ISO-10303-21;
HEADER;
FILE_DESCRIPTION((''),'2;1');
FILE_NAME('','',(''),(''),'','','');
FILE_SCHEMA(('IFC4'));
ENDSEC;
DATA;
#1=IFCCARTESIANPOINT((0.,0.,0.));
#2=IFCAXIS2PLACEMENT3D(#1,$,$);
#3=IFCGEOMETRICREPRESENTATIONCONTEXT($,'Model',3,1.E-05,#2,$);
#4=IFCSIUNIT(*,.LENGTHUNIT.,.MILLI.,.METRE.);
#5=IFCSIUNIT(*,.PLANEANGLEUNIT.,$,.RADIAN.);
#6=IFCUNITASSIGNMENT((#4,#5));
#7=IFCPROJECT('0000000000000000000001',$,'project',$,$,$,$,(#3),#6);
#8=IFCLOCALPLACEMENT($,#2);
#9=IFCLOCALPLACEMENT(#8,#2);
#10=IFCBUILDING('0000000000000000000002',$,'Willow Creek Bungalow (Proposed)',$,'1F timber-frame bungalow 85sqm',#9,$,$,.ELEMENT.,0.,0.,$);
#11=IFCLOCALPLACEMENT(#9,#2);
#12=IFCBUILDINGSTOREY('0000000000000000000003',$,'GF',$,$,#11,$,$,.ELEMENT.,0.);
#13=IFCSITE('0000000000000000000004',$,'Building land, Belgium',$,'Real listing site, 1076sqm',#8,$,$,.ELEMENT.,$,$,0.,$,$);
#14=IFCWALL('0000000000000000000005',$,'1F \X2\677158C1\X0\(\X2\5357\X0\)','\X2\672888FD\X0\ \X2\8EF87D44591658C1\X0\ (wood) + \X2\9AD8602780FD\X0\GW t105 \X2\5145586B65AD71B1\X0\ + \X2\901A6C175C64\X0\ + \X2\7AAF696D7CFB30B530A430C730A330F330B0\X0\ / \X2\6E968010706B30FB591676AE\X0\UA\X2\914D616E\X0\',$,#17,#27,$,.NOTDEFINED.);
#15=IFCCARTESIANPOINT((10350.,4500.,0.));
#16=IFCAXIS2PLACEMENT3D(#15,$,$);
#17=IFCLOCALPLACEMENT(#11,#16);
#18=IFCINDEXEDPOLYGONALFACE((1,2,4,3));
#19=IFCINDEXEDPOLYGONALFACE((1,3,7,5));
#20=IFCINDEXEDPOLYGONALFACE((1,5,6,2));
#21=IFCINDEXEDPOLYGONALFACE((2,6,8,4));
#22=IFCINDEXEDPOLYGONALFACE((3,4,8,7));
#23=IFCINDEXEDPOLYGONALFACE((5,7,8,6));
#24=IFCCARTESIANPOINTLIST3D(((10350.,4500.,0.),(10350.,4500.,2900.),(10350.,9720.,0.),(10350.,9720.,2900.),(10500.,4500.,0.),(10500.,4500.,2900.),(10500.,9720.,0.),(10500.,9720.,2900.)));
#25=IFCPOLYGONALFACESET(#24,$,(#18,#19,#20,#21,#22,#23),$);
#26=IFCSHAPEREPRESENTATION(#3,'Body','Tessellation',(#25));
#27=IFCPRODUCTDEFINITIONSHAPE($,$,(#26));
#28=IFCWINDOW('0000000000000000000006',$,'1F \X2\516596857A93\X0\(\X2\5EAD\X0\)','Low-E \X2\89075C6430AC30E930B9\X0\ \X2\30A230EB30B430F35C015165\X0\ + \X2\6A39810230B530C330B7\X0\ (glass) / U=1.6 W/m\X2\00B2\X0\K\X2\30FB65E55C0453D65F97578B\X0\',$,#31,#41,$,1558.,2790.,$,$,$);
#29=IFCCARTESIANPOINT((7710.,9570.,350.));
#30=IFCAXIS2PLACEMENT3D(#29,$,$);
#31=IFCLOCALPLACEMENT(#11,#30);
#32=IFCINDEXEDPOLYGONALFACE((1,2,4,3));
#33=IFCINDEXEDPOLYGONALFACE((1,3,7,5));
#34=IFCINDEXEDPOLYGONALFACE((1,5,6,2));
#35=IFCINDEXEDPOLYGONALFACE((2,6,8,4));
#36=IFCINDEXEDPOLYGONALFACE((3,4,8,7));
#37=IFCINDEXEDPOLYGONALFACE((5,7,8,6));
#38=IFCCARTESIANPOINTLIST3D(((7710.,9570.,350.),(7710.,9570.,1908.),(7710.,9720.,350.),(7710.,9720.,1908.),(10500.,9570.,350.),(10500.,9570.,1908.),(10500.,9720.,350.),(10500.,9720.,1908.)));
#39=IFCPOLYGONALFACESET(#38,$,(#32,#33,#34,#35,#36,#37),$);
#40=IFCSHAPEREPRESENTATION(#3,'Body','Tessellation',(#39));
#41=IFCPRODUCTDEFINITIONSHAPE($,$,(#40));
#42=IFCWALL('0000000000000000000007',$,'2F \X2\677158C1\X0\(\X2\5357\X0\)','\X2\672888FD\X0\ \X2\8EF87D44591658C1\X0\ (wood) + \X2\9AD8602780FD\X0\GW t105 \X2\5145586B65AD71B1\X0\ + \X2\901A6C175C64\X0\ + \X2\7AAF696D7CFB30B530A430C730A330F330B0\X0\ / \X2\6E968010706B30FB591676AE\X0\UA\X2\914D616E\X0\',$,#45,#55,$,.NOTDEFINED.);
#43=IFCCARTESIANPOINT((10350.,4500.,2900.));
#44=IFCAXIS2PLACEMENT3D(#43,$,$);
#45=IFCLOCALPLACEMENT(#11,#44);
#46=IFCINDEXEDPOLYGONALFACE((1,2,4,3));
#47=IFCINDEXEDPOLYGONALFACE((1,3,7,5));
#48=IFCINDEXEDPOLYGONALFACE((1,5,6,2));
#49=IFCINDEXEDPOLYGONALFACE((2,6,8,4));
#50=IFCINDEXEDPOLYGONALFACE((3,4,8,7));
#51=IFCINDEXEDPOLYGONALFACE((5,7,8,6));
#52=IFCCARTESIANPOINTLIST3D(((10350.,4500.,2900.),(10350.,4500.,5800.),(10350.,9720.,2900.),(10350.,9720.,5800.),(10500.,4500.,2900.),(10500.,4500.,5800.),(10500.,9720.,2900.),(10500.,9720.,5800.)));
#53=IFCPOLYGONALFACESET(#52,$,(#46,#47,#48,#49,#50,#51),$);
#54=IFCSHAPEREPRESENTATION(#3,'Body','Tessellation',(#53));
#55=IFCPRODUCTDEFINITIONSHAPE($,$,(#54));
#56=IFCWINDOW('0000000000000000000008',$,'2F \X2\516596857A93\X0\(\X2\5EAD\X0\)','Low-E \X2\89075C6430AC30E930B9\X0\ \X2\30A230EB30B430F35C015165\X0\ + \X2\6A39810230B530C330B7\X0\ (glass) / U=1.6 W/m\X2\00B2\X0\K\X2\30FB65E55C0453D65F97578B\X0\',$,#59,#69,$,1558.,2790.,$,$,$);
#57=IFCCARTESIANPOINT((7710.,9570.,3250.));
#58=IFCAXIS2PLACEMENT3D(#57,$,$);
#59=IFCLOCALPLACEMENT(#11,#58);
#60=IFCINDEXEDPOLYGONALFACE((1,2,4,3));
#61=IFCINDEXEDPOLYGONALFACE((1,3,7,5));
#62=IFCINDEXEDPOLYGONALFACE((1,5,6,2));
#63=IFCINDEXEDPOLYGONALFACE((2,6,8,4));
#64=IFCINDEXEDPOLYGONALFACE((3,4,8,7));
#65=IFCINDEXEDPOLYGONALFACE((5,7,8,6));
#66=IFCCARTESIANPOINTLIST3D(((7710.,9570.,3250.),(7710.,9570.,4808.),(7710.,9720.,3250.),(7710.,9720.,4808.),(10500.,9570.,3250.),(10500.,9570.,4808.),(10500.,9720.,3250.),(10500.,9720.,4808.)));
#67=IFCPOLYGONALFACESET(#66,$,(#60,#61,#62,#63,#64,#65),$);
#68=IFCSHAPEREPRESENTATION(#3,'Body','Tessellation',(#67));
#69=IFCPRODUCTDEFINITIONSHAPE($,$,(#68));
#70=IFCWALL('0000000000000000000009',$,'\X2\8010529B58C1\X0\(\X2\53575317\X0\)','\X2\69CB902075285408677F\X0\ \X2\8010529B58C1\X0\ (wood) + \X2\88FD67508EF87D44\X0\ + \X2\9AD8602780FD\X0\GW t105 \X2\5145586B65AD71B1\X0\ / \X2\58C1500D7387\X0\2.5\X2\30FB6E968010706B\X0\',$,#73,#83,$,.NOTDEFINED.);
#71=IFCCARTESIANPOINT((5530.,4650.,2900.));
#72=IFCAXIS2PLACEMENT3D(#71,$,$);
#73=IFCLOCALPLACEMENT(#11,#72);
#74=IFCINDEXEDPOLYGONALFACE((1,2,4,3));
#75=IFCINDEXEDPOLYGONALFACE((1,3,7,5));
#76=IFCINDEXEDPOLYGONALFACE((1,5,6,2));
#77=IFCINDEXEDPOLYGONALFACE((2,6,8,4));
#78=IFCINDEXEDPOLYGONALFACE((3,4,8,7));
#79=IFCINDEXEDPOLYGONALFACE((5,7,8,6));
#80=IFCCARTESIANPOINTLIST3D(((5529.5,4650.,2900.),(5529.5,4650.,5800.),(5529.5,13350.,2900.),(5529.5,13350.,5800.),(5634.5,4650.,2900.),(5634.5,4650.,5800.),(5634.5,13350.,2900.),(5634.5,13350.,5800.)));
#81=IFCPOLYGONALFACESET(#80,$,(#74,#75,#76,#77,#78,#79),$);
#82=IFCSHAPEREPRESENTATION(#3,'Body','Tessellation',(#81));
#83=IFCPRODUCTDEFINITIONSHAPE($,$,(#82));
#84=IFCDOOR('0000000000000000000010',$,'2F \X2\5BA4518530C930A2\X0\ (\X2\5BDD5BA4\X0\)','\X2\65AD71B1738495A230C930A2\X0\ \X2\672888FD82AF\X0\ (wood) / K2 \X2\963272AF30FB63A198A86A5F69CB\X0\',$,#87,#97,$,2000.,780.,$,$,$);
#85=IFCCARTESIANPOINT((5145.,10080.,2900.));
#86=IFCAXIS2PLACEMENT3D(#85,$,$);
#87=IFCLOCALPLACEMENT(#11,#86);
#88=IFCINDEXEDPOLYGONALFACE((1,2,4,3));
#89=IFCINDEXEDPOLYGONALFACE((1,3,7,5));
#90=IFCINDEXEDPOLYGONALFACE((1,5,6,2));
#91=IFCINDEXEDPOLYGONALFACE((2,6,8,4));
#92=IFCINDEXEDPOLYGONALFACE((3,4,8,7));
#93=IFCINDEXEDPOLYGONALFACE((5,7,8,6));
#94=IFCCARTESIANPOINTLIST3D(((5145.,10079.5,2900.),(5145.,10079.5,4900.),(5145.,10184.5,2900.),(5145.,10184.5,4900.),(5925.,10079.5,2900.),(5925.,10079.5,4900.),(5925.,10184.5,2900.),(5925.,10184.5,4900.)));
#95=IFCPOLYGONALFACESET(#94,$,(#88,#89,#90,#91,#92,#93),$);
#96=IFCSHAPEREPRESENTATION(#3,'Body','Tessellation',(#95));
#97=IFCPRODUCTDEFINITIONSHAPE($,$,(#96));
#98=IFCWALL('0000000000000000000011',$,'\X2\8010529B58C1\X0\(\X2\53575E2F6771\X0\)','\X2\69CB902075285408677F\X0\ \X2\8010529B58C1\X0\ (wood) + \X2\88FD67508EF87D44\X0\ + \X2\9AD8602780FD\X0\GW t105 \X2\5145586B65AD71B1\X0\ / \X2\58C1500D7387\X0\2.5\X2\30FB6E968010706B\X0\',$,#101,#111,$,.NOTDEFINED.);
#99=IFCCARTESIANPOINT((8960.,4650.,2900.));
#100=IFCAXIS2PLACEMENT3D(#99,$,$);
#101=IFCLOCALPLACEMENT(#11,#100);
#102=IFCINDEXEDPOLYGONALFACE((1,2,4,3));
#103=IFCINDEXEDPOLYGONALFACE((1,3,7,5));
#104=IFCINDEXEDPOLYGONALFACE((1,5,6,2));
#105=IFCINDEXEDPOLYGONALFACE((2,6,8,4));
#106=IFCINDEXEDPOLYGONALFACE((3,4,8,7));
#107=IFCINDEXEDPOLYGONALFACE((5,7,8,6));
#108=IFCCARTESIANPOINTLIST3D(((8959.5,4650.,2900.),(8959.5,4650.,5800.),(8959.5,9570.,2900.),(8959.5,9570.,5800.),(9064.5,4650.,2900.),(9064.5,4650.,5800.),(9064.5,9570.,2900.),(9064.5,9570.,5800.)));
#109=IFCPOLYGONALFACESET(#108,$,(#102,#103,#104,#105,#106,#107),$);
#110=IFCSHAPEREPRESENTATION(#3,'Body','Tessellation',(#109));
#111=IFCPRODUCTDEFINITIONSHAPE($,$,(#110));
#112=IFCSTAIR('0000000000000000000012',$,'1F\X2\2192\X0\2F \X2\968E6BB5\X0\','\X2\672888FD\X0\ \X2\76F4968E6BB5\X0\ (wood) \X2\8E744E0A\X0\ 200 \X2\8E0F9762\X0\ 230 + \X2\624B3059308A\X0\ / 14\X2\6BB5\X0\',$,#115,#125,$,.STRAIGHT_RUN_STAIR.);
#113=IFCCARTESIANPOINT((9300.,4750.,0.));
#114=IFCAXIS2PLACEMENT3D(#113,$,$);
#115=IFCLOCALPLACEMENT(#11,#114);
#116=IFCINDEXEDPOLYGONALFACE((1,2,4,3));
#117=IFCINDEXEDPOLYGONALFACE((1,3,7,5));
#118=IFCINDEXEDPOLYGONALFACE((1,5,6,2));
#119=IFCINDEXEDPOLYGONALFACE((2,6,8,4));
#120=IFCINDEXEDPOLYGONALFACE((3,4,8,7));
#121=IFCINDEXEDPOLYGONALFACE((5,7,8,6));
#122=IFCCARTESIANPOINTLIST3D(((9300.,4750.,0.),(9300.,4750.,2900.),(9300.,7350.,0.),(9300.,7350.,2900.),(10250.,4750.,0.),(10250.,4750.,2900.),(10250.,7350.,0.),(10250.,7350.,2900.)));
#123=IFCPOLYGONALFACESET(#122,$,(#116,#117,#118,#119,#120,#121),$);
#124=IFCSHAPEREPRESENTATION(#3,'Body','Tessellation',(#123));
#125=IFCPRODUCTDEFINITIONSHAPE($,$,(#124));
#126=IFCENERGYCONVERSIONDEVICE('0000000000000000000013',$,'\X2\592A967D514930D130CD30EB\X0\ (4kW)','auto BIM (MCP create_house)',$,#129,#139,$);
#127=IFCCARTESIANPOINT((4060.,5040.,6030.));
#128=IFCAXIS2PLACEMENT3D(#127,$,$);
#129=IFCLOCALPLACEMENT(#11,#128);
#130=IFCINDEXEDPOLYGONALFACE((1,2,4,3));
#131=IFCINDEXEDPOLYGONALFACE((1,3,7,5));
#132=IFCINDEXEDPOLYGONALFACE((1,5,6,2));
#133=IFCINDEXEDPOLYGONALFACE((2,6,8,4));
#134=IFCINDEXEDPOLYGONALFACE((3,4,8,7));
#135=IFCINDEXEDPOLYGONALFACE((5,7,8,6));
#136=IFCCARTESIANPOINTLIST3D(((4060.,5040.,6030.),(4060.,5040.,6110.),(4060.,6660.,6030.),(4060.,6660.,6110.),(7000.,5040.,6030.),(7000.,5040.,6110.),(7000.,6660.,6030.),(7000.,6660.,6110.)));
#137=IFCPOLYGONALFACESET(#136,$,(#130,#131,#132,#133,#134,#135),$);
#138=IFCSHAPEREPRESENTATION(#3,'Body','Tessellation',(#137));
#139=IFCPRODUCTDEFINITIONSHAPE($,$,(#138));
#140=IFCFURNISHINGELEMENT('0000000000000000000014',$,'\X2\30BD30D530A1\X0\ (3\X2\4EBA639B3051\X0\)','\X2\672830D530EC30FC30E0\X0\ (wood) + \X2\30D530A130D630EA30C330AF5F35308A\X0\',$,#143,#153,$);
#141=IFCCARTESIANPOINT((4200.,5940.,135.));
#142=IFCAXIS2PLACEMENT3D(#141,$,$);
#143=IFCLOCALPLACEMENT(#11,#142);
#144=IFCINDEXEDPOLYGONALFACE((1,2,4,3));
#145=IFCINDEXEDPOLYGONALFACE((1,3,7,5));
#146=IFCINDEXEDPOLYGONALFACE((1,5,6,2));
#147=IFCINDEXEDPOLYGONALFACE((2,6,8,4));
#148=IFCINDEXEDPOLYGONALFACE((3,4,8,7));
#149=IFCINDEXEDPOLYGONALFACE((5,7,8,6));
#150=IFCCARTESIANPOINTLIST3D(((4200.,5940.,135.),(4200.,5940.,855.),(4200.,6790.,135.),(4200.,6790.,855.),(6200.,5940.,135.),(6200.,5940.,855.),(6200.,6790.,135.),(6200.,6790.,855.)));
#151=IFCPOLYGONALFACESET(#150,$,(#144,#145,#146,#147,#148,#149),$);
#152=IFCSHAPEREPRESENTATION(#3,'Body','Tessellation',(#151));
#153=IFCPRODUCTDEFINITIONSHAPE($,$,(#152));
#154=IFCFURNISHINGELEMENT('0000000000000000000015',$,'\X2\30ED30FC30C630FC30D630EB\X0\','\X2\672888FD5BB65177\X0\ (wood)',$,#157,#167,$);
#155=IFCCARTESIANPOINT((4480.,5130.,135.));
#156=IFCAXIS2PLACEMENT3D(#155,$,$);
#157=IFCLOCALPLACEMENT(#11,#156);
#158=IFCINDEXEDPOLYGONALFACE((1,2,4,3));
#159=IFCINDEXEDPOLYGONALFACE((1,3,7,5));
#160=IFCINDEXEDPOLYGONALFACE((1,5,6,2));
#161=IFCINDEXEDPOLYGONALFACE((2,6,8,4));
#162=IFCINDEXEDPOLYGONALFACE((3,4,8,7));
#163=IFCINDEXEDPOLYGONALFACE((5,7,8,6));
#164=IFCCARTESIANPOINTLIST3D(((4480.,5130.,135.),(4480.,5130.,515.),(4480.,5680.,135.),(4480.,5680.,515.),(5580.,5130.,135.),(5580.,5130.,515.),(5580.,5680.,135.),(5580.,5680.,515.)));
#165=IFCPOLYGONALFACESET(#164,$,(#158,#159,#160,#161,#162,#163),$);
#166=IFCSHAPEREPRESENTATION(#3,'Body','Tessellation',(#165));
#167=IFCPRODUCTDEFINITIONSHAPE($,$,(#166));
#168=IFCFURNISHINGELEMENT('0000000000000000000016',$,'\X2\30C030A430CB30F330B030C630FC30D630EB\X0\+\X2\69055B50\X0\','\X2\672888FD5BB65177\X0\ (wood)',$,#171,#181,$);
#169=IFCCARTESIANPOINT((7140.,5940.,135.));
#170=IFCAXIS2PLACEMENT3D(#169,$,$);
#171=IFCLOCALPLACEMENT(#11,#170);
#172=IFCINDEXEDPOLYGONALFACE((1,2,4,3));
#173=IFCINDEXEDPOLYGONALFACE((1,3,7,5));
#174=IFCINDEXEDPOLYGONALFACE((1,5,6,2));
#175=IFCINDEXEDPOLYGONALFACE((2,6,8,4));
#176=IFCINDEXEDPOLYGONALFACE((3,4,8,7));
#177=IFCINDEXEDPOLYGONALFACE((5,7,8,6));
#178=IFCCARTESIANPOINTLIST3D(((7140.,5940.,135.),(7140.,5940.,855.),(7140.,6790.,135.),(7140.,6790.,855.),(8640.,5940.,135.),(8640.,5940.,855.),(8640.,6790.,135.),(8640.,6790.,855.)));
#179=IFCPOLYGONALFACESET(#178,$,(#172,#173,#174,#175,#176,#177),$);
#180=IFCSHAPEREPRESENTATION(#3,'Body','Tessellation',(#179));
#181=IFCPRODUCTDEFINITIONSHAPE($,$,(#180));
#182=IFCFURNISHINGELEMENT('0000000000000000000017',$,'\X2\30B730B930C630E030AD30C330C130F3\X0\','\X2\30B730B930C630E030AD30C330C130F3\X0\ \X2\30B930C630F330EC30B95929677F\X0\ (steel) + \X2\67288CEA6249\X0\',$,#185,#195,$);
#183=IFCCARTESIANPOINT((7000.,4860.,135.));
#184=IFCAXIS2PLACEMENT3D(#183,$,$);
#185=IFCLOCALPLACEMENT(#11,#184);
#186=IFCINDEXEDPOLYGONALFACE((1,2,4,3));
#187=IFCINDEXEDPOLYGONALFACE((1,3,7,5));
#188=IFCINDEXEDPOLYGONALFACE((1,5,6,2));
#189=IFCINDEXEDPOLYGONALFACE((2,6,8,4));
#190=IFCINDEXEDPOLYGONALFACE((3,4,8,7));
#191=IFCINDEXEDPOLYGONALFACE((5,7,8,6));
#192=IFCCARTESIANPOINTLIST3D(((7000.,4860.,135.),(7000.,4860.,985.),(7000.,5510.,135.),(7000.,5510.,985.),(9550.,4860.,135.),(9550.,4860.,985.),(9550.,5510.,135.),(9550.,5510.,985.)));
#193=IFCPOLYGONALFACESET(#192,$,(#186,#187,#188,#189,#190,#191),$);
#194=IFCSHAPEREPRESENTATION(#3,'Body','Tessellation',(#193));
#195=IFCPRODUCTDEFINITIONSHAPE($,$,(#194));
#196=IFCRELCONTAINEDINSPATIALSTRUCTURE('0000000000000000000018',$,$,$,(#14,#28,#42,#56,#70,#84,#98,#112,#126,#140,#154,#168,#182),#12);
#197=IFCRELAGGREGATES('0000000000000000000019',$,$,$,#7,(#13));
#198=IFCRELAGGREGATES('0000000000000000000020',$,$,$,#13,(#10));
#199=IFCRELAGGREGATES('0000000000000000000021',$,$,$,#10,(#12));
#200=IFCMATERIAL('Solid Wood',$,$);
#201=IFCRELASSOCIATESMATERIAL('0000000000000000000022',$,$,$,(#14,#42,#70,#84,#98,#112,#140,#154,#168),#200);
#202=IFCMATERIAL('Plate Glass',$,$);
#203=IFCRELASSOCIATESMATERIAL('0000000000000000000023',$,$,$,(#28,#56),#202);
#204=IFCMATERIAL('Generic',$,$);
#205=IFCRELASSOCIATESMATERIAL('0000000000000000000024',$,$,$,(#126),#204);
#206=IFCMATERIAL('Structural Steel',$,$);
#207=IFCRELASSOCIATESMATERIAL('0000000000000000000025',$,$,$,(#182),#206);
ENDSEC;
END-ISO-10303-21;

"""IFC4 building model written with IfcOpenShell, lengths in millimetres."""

from ifc_helpers import new_model, si_unit, frame, frame_2d, origin, place, context, project, spatial, rectangle, extrude, material, element, fill, save


model = new_model("IFC4")

# Units and contexts
model_context = context("Model", 3, precision=1e-05, world=origin())
ifc_project = project(units=[si_unit("LENGTHUNIT", "METRE", prefix="MILLI"), si_unit("PLANEANGLEUNIT", "RADIAN")], contexts=[model_context])

# Site, building, storey
site_placement = place(None, origin())
site = spatial("IfcSite", under=ifc_project, at=site_placement, Name="Building land, Belgium", ObjectType="Real listing site, 1076sqm", CompositionType="ELEMENT", RefElevation=0.0)
building_placement = place(site_placement, origin())
building = spatial("IfcBuilding", under=site, at=building_placement, Name="Willow Creek Bungalow (Proposed)", ObjectType="1F timber-frame bungalow 85sqm", CompositionType="ELEMENT", ElevationOfRefHeight=0.0, ElevationOfTerrain=0.0)
storey_placement = place(building_placement, origin())
storey = spatial("IfcBuildingStorey", under=building, at=storey_placement, Name="GF", CompositionType="ELEMENT", Elevation=0.0)

# Wall, opening, window
ifc_material_1 = material(Name="Solid Wood")
wall_1_placement = place(storey_placement, frame((10350.0, 4500.0, 0.0)))
wall_1 = element("IfcWall", 1, at=wall_1_placement, inside=storey, material=ifc_material_1, Name="1F 東壁(南)", Description="木製 軸組外壁 (wood) + 高性能GW t105 充填断熱 + 通気層 + 窯業系サイディング / 準耐火・外皮UA配慮", PredefinedType="NOTDEFINED", context=model_context, shape_type="SweptSolid", body=[
    extrude(rectangle(XDim=150.0, YDim=5220.0, at=frame_2d((75.0, 2610.0))), frame((10350.0, 4500.0, 0.0)), (0.0, 0.0, 1.0), 2900.0),
])
opening_1_placement = place(storey_placement, frame((7710.0, 9570.0, 350.0)))
opening_1 = element("IfcOpeningElement", 2, at=opening_1_placement, cuts=wall_1, PredefinedType="NOTDEFINED", context=model_context, shape_type="SweptSolid", body=[
    extrude(rectangle(XDim=2790.0, YDim=150.0, at=frame_2d((1395.0, 75.0))), frame((7710.0, 9570.0, 350.0)), (0.0, 0.0, 1.0), 1558.0),
])
ifc_material_2 = material(Name="Plate Glass")
window_1_placement = place(storey_placement, frame((7710.0, 9570.0, 350.0)))
window_1 = element("IfcWindow", 3, at=window_1_placement, inside=storey, material=ifc_material_2, Name="1F 入隅窓(庭)", Description="Low-E 複層ガラス アルゴン封入 + 樹脂サッシ (glass) / U=1.6 W/m²K・日射取得型", OverallHeight=1558.0, OverallWidth=2790.0, context=model_context, shape_type="SweptSolid", body=[
    extrude(rectangle(XDim=2790.0, YDim=150.0, at=frame_2d((1395.0, 75.0))), frame((7710.0, 9570.0, 350.0)), (0.0, 0.0, 1.0), 1558.0),
])
fill(opening_1, window_1)

# Wall, opening, window
wall_2_placement = place(storey_placement, frame((10350.0, 4500.0, 2900.0)))
wall_2 = element("IfcWall", 4, at=wall_2_placement, inside=storey, material=ifc_material_1, Name="2F 東壁(南)", Description="木製 軸組外壁 (wood) + 高性能GW t105 充填断熱 + 通気層 + 窯業系サイディング / 準耐火・外皮UA配慮", PredefinedType="NOTDEFINED", context=model_context, shape_type="SweptSolid", body=[
    extrude(rectangle(XDim=150.0, YDim=5220.0, at=frame_2d((75.0, 2610.0))), frame((10350.0, 4500.0, 2900.0)), (0.0, 0.0, 1.0), 2900.0),
])
opening_2_placement = place(storey_placement, frame((7710.0, 9570.0, 3250.0)))
opening_2 = element("IfcOpeningElement", 5, at=opening_2_placement, cuts=wall_2, PredefinedType="NOTDEFINED", context=model_context, shape_type="SweptSolid", body=[
    extrude(rectangle(XDim=2790.0, YDim=150.0, at=frame_2d((1395.0, 75.0))), frame((7710.0, 9570.0, 3250.0)), (0.0, 0.0, 1.0), 1558.0),
])
window_2_placement = place(storey_placement, frame((7710.0, 9570.0, 3250.0)))
window_2 = element("IfcWindow", 6, at=window_2_placement, inside=storey, material=ifc_material_2, Name="2F 入隅窓(庭)", Description="Low-E 複層ガラス アルゴン封入 + 樹脂サッシ (glass) / U=1.6 W/m²K・日射取得型", OverallHeight=1558.0, OverallWidth=2790.0, context=model_context, shape_type="SweptSolid", body=[
    extrude(rectangle(XDim=2790.0, YDim=150.0, at=frame_2d((1395.0, 75.0))), frame((7710.0, 9570.0, 3250.0)), (0.0, 0.0, 1.0), 1558.0),
])
fill(opening_2, window_2)

# Wall, opening, door
wall_3_placement = place(storey_placement, frame((5530.0, 4650.0, 2900.0)))
wall_3 = element("IfcWall", 7, at=wall_3_placement, inside=storey, material=ifc_material_1, Name="耐力壁(南北)", Description="構造用合板 耐力壁 (wood) + 製材軸組 + 高性能GW t105 充填断熱 / 壁倍率2.5・準耐火", PredefinedType="NOTDEFINED", context=model_context, shape_type="SweptSolid", body=[
    extrude(rectangle(XDim=105.0, YDim=8700.0, at=frame_2d((52.0, 4350.0))), frame((5530.0, 4650.0, 2900.0)), (0.0, 0.0, 1.0), 2900.0),
])
opening_3_placement = place(storey_placement, frame((5145.0, 10080.0, 2900.0)))
opening_3 = element("IfcOpeningElement", 8, at=opening_3_placement, cuts=wall_3, PredefinedType="NOTDEFINED", context=model_context, shape_type="SweptSolid", body=[
    extrude(rectangle(XDim=780.0, YDim=105.0, at=frame_2d((390.0, 52.0))), frame((5145.0, 10080.0, 2900.0)), (0.0, 0.0, 1.0), 2000.0),
])
door_1_placement = place(storey_placement, frame((5145.0, 10080.0, 2900.0)))
door_1 = element("IfcDoor", 9, at=door_1_placement, inside=storey, material=ifc_material_1, Name="2F 室内ドア (寝室)", Description="断熱玄関ドア 木製芯 (wood) / K2 防犯・採風機構", OverallHeight=2000.0, OverallWidth=780.0, context=model_context, shape_type="SweptSolid", body=[
    extrude(rectangle(XDim=780.0, YDim=105.0, at=frame_2d((390.0, 52.0))), frame((5145.0, 10080.0, 2900.0)), (0.0, 0.0, 1.0), 2000.0),
])
fill(opening_3, door_1)

# Wall
wall_4_placement = place(storey_placement, frame((8960.0, 4650.0, 2900.0)))
element("IfcWall", 10, at=wall_4_placement, inside=storey, material=ifc_material_1, Name="耐力壁(南帯東)", Description="構造用合板 耐力壁 (wood) + 製材軸組 + 高性能GW t105 充填断熱 / 壁倍率2.5・準耐火", PredefinedType="NOTDEFINED", context=model_context, shape_type="SweptSolid", body=[
    extrude(rectangle(XDim=105.0, YDim=4920.0, at=frame_2d((52.0, 2460.0))), frame((8960.0, 4650.0, 2900.0)), (0.0, 0.0, 1.0), 2900.0),
])

# Stair
stair_placement = place(storey_placement, frame((9300.0, 4750.0, 0.0)))
element("IfcStair", 11, at=stair_placement, inside=storey, material=ifc_material_1, Name="1F→2F 階段", Description="木製 直階段 (wood) 蹴上 200 踏面 230 + 手すり / 14段", PredefinedType="STRAIGHT_RUN_STAIR", context=model_context, shape_type="SweptSolid", body=[
    extrude(rectangle(XDim=950.0, YDim=2600.0, at=frame_2d((475.0, 1300.0))), frame((9300.0, 4750.0, 0.0)), (0.0, 0.0, 1.0), 2900.0),
])

# Energy conversion device
ifc_material_3 = material(Name="Generic")
energy_conversion_device_placement = place(storey_placement, frame((4060.0, 5040.0, 6030.0)))
element("IfcEnergyConversionDevice", 12, at=energy_conversion_device_placement, inside=storey, material=ifc_material_3, Name="太陽光パネル (4kW)", Description="auto BIM (MCP create_house)", context=model_context, shape_type="SweptSolid", body=[
    extrude(rectangle(XDim=2940.0, YDim=1620.0, at=frame_2d((1470.0, 810.0))), frame((4060.0, 5040.0, 6030.0)), (0.0, 0.0, 1.0), 80.0),
])

# Furnishing elements
furnishing_1_placement = place(storey_placement, frame((4200.0, 5940.0, 135.0)))
element("IfcFurnishingElement", 13, at=furnishing_1_placement, inside=storey, material=ifc_material_1, Name="ソファ (3人掛け)", Description="木フレーム (wood) + ファブリック張り", context=model_context, shape_type="SweptSolid", body=[
    extrude(rectangle(XDim=2000.0, YDim=850.0, at=frame_2d((1000.0, 425.0))), frame((4200.0, 5940.0, 135.0)), (0.0, 0.0, 1.0), 720.0),
])
furnishing_2_placement = place(storey_placement, frame((4480.0, 5130.0, 135.0)))
element("IfcFurnishingElement", 14, at=furnishing_2_placement, inside=storey, material=ifc_material_1, Name="ローテーブル", Description="木製家具 (wood)", context=model_context, shape_type="SweptSolid", body=[
    extrude(rectangle(XDim=1100.0, YDim=550.0, at=frame_2d((550.0, 275.0))), frame((4480.0, 5130.0, 135.0)), (0.0, 0.0, 1.0), 380.0),
])
furnishing_3_placement = place(storey_placement, frame((7140.0, 5940.0, 135.0)))
element("IfcFurnishingElement", 15, at=furnishing_3_placement, inside=storey, material=ifc_material_1, Name="ダイニングテーブル+椅子", Description="木製家具 (wood)", context=model_context, shape_type="SweptSolid", body=[
    extrude(rectangle(XDim=1500.0, YDim=850.0, at=frame_2d((750.0, 425.0))), frame((7140.0, 5940.0, 135.0)), (0.0, 0.0, 1.0), 720.0),
])
ifc_material_4 = material(Name="Structural Steel")
furnishing_4_placement = place(storey_placement, frame((7000.0, 4860.0, 135.0)))
element("IfcFurnishingElement", 16, at=furnishing_4_placement, inside=storey, material=ifc_material_4, Name="システムキッチン", Description="システムキッチン ステンレス天板 (steel) + 木質扉", context=model_context, shape_type="SweptSolid", body=[
    extrude(rectangle(XDim=2550.0, YDim=650.0, at=frame_2d((1275.0, 325.0))), frame((7000.0, 4860.0, 135.0)), (0.0, 0.0, 1.0), 850.0),
])

save(model, "model.ifc")
